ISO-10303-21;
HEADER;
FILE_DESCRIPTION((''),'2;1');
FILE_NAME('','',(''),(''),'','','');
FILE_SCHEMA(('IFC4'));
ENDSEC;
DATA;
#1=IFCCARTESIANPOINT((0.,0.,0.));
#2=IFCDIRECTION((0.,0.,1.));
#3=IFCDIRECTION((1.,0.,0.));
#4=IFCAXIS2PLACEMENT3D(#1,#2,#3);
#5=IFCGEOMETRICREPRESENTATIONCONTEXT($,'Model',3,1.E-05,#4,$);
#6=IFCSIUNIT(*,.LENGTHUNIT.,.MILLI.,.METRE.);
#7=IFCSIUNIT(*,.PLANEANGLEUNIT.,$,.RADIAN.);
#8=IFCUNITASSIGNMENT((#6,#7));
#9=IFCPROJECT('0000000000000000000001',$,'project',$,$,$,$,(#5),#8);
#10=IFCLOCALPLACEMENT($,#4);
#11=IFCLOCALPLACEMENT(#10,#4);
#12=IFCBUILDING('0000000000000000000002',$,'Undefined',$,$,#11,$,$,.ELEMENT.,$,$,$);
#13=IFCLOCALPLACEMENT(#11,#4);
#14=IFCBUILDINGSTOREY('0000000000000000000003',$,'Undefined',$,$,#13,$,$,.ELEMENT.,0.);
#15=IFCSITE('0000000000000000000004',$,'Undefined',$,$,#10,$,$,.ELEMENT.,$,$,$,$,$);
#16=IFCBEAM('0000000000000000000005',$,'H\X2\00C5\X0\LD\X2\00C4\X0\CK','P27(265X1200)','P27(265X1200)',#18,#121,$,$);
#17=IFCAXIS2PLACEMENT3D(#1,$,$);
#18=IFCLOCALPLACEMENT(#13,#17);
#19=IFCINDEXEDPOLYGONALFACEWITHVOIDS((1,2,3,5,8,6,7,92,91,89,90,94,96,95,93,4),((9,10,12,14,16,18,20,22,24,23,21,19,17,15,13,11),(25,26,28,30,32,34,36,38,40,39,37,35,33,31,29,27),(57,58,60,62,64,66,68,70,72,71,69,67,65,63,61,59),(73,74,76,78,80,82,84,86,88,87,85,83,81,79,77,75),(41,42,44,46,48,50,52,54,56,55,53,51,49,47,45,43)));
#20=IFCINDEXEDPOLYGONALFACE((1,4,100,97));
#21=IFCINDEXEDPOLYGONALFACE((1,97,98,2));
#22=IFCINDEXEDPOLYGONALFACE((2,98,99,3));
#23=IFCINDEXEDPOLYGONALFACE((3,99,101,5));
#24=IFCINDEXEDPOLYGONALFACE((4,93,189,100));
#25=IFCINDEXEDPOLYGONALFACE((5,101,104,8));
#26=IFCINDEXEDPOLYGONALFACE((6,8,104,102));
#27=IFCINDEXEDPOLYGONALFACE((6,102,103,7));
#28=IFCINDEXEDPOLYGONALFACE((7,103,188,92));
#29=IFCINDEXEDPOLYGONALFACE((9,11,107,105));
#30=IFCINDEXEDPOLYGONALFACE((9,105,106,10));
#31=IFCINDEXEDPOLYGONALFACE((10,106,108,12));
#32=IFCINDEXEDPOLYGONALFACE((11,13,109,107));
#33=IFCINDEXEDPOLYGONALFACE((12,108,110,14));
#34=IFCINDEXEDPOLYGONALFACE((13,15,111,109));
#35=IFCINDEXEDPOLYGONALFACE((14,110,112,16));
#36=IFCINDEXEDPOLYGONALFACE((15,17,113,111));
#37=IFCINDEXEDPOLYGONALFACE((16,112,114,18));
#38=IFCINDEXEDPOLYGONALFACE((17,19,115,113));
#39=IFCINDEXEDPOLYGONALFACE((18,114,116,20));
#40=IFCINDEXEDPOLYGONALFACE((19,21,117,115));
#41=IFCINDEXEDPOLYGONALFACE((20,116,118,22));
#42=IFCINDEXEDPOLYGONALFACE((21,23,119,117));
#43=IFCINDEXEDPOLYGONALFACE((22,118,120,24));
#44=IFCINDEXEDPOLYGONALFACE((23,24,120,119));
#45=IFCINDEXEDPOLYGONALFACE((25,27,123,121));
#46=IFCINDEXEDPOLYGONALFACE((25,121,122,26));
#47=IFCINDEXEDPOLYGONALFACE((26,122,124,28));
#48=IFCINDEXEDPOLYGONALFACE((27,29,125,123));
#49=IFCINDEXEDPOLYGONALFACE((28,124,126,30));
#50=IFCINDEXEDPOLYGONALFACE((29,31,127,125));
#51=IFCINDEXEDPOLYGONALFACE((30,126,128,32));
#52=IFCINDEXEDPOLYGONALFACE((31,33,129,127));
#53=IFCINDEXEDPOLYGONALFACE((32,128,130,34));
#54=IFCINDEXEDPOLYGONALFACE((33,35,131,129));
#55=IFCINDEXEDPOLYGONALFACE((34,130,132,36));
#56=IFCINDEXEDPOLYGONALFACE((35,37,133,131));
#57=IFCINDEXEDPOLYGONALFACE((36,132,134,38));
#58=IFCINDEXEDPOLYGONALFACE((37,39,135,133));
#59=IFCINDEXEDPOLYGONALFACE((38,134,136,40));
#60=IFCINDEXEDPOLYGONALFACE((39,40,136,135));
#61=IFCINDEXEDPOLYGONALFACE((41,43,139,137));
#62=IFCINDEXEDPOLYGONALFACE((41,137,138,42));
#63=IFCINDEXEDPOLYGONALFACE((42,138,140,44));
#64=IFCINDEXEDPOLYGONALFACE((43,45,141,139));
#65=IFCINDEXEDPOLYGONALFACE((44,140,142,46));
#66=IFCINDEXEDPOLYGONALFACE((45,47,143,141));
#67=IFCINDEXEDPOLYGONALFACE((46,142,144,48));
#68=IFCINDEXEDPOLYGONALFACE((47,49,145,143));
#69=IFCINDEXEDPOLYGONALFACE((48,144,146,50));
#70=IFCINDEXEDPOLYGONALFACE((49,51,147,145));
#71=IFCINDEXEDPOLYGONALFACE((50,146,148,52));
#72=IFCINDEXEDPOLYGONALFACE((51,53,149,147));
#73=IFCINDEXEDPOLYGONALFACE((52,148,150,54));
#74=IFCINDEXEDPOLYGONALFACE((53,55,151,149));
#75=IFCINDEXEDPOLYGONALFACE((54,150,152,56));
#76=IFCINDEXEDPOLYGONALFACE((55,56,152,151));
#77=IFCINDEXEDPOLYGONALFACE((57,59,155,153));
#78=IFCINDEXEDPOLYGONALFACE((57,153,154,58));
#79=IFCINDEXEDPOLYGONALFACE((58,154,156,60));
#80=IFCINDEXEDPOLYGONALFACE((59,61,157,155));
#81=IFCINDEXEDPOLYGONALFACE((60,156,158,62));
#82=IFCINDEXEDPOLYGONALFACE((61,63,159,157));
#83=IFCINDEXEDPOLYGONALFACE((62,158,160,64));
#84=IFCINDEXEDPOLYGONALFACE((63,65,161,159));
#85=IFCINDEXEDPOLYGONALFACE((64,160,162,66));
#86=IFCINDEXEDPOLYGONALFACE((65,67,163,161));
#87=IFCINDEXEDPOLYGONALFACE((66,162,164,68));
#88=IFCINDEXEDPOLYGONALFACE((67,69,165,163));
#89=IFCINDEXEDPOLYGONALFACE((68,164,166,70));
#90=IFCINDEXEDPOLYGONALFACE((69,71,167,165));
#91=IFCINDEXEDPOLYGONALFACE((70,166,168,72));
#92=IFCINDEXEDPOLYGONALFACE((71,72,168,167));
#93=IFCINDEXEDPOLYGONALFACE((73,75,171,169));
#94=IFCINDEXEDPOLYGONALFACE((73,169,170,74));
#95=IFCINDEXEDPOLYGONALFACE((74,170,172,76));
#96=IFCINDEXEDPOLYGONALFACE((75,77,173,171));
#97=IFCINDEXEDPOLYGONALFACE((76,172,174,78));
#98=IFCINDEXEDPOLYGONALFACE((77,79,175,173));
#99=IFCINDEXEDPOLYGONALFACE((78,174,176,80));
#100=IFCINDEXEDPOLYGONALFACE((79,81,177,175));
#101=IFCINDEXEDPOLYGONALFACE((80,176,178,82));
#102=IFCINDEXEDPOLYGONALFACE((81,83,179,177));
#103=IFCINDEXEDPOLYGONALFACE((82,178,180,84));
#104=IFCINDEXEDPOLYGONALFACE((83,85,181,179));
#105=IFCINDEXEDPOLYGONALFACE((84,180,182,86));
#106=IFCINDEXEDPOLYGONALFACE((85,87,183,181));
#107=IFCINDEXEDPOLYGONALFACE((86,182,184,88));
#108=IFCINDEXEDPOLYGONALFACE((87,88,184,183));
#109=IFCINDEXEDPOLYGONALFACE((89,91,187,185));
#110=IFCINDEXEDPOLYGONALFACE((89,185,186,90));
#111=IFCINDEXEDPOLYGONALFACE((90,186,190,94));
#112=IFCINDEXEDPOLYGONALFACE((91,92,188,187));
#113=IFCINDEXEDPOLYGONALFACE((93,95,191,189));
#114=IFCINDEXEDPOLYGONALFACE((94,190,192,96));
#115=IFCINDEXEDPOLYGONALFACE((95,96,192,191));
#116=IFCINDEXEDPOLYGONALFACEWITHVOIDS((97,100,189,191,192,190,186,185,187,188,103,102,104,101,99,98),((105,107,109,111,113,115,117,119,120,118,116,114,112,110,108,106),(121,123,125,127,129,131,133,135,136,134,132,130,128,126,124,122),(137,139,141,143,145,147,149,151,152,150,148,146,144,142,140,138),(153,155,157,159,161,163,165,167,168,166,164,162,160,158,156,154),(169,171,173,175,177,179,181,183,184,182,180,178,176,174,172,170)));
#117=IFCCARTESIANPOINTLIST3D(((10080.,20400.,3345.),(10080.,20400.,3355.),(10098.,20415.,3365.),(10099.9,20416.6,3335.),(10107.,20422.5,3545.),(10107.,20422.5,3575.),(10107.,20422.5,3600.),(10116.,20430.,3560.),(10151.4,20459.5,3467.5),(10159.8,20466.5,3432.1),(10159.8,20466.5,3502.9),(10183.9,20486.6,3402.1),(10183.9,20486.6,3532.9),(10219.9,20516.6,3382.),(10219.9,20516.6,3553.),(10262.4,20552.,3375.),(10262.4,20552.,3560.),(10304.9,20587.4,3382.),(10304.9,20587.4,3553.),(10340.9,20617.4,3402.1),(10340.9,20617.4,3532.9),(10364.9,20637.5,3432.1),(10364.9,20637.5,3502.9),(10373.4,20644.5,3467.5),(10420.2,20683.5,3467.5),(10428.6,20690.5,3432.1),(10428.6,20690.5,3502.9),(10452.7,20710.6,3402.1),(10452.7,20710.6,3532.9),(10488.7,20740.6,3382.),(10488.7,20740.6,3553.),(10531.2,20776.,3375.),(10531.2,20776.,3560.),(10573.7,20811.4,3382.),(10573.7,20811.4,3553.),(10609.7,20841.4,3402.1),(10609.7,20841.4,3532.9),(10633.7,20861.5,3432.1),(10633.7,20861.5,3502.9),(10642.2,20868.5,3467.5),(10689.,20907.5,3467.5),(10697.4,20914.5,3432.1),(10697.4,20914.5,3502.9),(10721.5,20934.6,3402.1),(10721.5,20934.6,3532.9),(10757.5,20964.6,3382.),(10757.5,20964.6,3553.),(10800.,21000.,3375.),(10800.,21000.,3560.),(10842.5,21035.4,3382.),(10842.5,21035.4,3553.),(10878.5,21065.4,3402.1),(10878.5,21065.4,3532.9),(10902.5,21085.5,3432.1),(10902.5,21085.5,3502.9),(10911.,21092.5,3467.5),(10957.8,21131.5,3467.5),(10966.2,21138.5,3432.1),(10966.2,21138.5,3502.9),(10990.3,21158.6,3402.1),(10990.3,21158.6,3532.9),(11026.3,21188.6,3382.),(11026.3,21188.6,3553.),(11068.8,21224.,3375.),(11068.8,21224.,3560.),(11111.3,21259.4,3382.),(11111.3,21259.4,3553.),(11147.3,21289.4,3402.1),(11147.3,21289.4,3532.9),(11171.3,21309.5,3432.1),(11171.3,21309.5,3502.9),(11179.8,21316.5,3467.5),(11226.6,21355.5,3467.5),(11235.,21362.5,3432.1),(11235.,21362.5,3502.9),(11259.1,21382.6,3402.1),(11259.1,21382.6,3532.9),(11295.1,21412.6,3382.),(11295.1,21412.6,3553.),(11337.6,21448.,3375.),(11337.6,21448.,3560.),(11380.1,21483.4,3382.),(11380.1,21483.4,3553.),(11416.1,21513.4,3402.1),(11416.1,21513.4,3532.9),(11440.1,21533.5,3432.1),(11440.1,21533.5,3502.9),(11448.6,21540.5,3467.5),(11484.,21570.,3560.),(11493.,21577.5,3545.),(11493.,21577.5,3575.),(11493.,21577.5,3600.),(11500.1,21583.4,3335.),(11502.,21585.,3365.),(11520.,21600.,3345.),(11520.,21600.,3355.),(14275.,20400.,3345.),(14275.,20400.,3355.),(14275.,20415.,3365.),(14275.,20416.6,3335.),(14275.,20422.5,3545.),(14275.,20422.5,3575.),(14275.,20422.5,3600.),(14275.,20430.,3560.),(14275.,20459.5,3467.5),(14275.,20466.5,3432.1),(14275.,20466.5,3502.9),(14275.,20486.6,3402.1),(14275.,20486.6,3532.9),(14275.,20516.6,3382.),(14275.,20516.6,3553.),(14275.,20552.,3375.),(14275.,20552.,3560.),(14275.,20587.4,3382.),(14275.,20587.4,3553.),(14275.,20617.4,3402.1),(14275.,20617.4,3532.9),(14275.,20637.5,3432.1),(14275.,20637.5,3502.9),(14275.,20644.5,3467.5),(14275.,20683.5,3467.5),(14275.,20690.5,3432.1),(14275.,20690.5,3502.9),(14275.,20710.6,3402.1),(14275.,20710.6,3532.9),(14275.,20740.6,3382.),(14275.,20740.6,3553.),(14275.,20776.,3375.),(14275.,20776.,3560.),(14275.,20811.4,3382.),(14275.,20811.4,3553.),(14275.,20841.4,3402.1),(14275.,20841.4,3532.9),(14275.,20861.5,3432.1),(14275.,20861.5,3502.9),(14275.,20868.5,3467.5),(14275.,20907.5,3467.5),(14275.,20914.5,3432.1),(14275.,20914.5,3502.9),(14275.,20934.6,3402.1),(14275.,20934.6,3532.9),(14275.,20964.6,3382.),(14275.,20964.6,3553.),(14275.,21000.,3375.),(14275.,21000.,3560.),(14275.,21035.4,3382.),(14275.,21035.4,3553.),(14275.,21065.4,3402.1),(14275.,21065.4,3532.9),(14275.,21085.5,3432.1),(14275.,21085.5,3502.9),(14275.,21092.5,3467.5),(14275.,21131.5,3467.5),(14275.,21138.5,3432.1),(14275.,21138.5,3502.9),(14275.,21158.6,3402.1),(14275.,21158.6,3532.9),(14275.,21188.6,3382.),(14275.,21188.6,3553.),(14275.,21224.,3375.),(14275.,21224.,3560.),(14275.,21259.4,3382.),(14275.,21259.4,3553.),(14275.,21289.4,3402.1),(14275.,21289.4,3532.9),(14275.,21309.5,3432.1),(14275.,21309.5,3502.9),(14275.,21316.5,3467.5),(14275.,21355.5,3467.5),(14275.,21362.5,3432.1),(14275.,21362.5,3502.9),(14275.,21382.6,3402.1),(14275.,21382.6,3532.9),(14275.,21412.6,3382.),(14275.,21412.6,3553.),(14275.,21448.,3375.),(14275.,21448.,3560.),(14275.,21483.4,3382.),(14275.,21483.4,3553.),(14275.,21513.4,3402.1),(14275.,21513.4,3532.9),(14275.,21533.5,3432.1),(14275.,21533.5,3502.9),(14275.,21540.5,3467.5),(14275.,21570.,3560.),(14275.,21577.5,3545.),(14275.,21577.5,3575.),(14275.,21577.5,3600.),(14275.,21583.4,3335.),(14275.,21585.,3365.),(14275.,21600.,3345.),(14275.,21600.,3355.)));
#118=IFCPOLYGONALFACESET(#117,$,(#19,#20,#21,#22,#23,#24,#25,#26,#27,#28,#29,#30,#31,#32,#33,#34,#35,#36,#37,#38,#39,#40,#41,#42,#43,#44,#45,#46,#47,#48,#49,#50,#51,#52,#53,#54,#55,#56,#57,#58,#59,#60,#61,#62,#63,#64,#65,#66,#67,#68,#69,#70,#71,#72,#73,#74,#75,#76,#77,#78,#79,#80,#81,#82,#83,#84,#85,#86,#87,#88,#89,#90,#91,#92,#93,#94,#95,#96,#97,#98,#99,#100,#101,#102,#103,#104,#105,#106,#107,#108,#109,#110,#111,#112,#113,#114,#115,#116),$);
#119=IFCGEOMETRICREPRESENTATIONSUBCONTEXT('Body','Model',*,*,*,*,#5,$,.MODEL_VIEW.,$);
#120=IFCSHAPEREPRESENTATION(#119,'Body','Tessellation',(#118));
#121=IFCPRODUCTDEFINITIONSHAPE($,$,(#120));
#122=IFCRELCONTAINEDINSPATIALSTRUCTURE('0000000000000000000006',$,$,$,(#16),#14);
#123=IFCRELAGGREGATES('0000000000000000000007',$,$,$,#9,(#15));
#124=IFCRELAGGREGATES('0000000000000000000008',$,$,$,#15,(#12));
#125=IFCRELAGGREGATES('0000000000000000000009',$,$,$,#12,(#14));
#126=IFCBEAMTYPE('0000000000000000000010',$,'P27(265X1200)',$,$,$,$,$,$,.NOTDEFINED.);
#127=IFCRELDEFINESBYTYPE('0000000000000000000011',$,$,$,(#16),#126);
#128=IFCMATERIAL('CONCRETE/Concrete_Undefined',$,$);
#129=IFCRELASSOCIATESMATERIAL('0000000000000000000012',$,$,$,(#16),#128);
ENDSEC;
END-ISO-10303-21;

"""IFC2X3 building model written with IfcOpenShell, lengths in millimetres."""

from ifc_helpers import new_model, si_unit, frame, origin_with_axes, place, context, subcontext, project, spatial, polyline, outline, extrude, clip, halfspace, material, type_object, element, save


model = new_model("IFC2X3")

# Units and contexts
model_context = context("Model", 3, precision=1e-05, world=origin_with_axes())
body_context = subcontext(model_context, "Body", "Model", "MODEL_VIEW")
ifc_project = project(units=[si_unit("LENGTHUNIT", "METRE", prefix="MILLI"), si_unit("PLANEANGLEUNIT", "RADIAN")], contexts=[model_context])

# Site, building, storey
site_placement = place(None, origin_with_axes())
site = spatial("IfcSite", under=ifc_project, at=site_placement, Name="Undefined", CompositionType="ELEMENT")
building_placement = place(site_placement, origin_with_axes())
building = spatial("IfcBuilding", under=site, at=building_placement, Name="Undefined", CompositionType="ELEMENT")
storey_placement = place(building_placement, origin_with_axes())
storey = spatial("IfcBuildingStorey", under=building, at=storey_placement, Name="Undefined", CompositionType="ELEMENT", Elevation=0.0)

# Beam
ifc_material_1 = material(Name="CONCRETE/Concrete_Undefined")
beam_type_1 = type_object("IfcBeamType", Name="P27(265X1200)", PredefinedType="NOTDEFINED")
beam_1_placement = place(storey_placement, frame((10080.0, 21000.0, 3467.5), z_axis=(0.0, 0.0, 1.0), x_axis=(1.0, 0.0, 0.0)))
element("IfcBeam", 1, at=beam_1_placement, inside=storey, type_object=beam_type_1, material=ifc_material_1, Name="HÅLDÄCK", Description="P27(265X1200)", ObjectType="P27(265X1200)", context=body_context, shape_type="Clipping", body=[
    clip(extrude(outline(polyline([(-583.4, -132.5), (-600.0, -122.5), (-600.0, -112.5), (-585.0, -102.5), (-577.5, 77.5), (-570.0, 92.5), (-577.5, 107.5), (-577.5, 132.5), (577.5, 132.5), (577.5, 107.5), (570.0, 92.5), (577.5, 77.5), (585.0, -102.5), (600.0, -112.5), (600.0, -122.5), (583.4, -132.5), (-583.4, -132.5)]), holes=[polyline([(-513.4, 65.4), (-533.5, 35.4), (-540.5, 0.0), (-533.5, -35.4), (-513.4, -65.4), (-483.4, -85.5), (-448.0, -92.5), (-412.6, -85.5), (-382.6, -65.4), (-362.5, -35.4), (-355.5, 0.0), (-362.5, 35.4), (-382.6, 65.4), (-412.6, 85.5), (-448.0, 92.5), (-483.4, 85.5), (-513.4, 65.4)]), polyline([(-289.4, 65.4), (-309.5, 35.4), (-316.5, 0.0), (-309.5, -35.4), (-289.4, -65.4), (-259.4, -85.5), (-224.0, -92.5), (-188.6, -85.5), (-158.6, -65.4), (-138.5, -35.4), (-131.5, 0.0), (-138.5, 35.4), (-158.6, 65.4), (-188.6, 85.5), (-224.0, 92.5), (-259.4, 85.5), (-289.4, 65.4)]), polyline([(-65.4, 65.4), (-85.5, 35.4), (-92.5, 0.0), (-85.5, -35.4), (-65.4, -65.4), (-35.4, -85.5), (0.0, -92.5), (35.4, -85.5), (65.4, -65.4), (85.5, -35.4), (92.5, 0.0), (85.5, 35.4), (65.4, 65.4), (35.4, 85.5), (0.0, 92.5), (-35.4, 85.5), (-65.4, 65.4)]), polyline([(158.6, 65.4), (138.5, 35.4), (131.5, 0.0), (138.5, -35.4), (158.6, -65.4), (188.6, -85.5), (224.0, -92.5), (259.4, -85.5), (289.4, -65.4), (309.5, -35.4), (316.5, 0.0), (309.5, 35.4), (289.4, 65.4), (259.4, 85.5), (224.0, 92.5), (188.6, 85.5), (158.6, 65.4)]), polyline([(382.6, 65.4), (362.5, 35.4), (355.5, 0.0), (362.5, -35.4), (382.6, -65.4), (412.6, -85.5), (448.0, -92.5), (483.4, -85.5), (513.4, -65.4), (533.5, -35.4), (540.5, 0.0), (533.5, 35.4), (513.4, 65.4), (483.4, 85.5), (448.0, 92.5), (412.6, 85.5), (382.6, 65.4)])]), frame((4195.0, 0.0, 0.0), z_axis=(-1.0, 0.0, 0.0), x_axis=(0.0, -1.0, 0.0)), (0.0, 0.0, 1.0), 4202.2), halfspace(frame((0.0, -600.0, 132.5), z_axis=(-0.640184, 0.768221, 0.0), x_axis=(0.0, 0.0, 1.0)), False)),
])

save(model, "model.ifc")
